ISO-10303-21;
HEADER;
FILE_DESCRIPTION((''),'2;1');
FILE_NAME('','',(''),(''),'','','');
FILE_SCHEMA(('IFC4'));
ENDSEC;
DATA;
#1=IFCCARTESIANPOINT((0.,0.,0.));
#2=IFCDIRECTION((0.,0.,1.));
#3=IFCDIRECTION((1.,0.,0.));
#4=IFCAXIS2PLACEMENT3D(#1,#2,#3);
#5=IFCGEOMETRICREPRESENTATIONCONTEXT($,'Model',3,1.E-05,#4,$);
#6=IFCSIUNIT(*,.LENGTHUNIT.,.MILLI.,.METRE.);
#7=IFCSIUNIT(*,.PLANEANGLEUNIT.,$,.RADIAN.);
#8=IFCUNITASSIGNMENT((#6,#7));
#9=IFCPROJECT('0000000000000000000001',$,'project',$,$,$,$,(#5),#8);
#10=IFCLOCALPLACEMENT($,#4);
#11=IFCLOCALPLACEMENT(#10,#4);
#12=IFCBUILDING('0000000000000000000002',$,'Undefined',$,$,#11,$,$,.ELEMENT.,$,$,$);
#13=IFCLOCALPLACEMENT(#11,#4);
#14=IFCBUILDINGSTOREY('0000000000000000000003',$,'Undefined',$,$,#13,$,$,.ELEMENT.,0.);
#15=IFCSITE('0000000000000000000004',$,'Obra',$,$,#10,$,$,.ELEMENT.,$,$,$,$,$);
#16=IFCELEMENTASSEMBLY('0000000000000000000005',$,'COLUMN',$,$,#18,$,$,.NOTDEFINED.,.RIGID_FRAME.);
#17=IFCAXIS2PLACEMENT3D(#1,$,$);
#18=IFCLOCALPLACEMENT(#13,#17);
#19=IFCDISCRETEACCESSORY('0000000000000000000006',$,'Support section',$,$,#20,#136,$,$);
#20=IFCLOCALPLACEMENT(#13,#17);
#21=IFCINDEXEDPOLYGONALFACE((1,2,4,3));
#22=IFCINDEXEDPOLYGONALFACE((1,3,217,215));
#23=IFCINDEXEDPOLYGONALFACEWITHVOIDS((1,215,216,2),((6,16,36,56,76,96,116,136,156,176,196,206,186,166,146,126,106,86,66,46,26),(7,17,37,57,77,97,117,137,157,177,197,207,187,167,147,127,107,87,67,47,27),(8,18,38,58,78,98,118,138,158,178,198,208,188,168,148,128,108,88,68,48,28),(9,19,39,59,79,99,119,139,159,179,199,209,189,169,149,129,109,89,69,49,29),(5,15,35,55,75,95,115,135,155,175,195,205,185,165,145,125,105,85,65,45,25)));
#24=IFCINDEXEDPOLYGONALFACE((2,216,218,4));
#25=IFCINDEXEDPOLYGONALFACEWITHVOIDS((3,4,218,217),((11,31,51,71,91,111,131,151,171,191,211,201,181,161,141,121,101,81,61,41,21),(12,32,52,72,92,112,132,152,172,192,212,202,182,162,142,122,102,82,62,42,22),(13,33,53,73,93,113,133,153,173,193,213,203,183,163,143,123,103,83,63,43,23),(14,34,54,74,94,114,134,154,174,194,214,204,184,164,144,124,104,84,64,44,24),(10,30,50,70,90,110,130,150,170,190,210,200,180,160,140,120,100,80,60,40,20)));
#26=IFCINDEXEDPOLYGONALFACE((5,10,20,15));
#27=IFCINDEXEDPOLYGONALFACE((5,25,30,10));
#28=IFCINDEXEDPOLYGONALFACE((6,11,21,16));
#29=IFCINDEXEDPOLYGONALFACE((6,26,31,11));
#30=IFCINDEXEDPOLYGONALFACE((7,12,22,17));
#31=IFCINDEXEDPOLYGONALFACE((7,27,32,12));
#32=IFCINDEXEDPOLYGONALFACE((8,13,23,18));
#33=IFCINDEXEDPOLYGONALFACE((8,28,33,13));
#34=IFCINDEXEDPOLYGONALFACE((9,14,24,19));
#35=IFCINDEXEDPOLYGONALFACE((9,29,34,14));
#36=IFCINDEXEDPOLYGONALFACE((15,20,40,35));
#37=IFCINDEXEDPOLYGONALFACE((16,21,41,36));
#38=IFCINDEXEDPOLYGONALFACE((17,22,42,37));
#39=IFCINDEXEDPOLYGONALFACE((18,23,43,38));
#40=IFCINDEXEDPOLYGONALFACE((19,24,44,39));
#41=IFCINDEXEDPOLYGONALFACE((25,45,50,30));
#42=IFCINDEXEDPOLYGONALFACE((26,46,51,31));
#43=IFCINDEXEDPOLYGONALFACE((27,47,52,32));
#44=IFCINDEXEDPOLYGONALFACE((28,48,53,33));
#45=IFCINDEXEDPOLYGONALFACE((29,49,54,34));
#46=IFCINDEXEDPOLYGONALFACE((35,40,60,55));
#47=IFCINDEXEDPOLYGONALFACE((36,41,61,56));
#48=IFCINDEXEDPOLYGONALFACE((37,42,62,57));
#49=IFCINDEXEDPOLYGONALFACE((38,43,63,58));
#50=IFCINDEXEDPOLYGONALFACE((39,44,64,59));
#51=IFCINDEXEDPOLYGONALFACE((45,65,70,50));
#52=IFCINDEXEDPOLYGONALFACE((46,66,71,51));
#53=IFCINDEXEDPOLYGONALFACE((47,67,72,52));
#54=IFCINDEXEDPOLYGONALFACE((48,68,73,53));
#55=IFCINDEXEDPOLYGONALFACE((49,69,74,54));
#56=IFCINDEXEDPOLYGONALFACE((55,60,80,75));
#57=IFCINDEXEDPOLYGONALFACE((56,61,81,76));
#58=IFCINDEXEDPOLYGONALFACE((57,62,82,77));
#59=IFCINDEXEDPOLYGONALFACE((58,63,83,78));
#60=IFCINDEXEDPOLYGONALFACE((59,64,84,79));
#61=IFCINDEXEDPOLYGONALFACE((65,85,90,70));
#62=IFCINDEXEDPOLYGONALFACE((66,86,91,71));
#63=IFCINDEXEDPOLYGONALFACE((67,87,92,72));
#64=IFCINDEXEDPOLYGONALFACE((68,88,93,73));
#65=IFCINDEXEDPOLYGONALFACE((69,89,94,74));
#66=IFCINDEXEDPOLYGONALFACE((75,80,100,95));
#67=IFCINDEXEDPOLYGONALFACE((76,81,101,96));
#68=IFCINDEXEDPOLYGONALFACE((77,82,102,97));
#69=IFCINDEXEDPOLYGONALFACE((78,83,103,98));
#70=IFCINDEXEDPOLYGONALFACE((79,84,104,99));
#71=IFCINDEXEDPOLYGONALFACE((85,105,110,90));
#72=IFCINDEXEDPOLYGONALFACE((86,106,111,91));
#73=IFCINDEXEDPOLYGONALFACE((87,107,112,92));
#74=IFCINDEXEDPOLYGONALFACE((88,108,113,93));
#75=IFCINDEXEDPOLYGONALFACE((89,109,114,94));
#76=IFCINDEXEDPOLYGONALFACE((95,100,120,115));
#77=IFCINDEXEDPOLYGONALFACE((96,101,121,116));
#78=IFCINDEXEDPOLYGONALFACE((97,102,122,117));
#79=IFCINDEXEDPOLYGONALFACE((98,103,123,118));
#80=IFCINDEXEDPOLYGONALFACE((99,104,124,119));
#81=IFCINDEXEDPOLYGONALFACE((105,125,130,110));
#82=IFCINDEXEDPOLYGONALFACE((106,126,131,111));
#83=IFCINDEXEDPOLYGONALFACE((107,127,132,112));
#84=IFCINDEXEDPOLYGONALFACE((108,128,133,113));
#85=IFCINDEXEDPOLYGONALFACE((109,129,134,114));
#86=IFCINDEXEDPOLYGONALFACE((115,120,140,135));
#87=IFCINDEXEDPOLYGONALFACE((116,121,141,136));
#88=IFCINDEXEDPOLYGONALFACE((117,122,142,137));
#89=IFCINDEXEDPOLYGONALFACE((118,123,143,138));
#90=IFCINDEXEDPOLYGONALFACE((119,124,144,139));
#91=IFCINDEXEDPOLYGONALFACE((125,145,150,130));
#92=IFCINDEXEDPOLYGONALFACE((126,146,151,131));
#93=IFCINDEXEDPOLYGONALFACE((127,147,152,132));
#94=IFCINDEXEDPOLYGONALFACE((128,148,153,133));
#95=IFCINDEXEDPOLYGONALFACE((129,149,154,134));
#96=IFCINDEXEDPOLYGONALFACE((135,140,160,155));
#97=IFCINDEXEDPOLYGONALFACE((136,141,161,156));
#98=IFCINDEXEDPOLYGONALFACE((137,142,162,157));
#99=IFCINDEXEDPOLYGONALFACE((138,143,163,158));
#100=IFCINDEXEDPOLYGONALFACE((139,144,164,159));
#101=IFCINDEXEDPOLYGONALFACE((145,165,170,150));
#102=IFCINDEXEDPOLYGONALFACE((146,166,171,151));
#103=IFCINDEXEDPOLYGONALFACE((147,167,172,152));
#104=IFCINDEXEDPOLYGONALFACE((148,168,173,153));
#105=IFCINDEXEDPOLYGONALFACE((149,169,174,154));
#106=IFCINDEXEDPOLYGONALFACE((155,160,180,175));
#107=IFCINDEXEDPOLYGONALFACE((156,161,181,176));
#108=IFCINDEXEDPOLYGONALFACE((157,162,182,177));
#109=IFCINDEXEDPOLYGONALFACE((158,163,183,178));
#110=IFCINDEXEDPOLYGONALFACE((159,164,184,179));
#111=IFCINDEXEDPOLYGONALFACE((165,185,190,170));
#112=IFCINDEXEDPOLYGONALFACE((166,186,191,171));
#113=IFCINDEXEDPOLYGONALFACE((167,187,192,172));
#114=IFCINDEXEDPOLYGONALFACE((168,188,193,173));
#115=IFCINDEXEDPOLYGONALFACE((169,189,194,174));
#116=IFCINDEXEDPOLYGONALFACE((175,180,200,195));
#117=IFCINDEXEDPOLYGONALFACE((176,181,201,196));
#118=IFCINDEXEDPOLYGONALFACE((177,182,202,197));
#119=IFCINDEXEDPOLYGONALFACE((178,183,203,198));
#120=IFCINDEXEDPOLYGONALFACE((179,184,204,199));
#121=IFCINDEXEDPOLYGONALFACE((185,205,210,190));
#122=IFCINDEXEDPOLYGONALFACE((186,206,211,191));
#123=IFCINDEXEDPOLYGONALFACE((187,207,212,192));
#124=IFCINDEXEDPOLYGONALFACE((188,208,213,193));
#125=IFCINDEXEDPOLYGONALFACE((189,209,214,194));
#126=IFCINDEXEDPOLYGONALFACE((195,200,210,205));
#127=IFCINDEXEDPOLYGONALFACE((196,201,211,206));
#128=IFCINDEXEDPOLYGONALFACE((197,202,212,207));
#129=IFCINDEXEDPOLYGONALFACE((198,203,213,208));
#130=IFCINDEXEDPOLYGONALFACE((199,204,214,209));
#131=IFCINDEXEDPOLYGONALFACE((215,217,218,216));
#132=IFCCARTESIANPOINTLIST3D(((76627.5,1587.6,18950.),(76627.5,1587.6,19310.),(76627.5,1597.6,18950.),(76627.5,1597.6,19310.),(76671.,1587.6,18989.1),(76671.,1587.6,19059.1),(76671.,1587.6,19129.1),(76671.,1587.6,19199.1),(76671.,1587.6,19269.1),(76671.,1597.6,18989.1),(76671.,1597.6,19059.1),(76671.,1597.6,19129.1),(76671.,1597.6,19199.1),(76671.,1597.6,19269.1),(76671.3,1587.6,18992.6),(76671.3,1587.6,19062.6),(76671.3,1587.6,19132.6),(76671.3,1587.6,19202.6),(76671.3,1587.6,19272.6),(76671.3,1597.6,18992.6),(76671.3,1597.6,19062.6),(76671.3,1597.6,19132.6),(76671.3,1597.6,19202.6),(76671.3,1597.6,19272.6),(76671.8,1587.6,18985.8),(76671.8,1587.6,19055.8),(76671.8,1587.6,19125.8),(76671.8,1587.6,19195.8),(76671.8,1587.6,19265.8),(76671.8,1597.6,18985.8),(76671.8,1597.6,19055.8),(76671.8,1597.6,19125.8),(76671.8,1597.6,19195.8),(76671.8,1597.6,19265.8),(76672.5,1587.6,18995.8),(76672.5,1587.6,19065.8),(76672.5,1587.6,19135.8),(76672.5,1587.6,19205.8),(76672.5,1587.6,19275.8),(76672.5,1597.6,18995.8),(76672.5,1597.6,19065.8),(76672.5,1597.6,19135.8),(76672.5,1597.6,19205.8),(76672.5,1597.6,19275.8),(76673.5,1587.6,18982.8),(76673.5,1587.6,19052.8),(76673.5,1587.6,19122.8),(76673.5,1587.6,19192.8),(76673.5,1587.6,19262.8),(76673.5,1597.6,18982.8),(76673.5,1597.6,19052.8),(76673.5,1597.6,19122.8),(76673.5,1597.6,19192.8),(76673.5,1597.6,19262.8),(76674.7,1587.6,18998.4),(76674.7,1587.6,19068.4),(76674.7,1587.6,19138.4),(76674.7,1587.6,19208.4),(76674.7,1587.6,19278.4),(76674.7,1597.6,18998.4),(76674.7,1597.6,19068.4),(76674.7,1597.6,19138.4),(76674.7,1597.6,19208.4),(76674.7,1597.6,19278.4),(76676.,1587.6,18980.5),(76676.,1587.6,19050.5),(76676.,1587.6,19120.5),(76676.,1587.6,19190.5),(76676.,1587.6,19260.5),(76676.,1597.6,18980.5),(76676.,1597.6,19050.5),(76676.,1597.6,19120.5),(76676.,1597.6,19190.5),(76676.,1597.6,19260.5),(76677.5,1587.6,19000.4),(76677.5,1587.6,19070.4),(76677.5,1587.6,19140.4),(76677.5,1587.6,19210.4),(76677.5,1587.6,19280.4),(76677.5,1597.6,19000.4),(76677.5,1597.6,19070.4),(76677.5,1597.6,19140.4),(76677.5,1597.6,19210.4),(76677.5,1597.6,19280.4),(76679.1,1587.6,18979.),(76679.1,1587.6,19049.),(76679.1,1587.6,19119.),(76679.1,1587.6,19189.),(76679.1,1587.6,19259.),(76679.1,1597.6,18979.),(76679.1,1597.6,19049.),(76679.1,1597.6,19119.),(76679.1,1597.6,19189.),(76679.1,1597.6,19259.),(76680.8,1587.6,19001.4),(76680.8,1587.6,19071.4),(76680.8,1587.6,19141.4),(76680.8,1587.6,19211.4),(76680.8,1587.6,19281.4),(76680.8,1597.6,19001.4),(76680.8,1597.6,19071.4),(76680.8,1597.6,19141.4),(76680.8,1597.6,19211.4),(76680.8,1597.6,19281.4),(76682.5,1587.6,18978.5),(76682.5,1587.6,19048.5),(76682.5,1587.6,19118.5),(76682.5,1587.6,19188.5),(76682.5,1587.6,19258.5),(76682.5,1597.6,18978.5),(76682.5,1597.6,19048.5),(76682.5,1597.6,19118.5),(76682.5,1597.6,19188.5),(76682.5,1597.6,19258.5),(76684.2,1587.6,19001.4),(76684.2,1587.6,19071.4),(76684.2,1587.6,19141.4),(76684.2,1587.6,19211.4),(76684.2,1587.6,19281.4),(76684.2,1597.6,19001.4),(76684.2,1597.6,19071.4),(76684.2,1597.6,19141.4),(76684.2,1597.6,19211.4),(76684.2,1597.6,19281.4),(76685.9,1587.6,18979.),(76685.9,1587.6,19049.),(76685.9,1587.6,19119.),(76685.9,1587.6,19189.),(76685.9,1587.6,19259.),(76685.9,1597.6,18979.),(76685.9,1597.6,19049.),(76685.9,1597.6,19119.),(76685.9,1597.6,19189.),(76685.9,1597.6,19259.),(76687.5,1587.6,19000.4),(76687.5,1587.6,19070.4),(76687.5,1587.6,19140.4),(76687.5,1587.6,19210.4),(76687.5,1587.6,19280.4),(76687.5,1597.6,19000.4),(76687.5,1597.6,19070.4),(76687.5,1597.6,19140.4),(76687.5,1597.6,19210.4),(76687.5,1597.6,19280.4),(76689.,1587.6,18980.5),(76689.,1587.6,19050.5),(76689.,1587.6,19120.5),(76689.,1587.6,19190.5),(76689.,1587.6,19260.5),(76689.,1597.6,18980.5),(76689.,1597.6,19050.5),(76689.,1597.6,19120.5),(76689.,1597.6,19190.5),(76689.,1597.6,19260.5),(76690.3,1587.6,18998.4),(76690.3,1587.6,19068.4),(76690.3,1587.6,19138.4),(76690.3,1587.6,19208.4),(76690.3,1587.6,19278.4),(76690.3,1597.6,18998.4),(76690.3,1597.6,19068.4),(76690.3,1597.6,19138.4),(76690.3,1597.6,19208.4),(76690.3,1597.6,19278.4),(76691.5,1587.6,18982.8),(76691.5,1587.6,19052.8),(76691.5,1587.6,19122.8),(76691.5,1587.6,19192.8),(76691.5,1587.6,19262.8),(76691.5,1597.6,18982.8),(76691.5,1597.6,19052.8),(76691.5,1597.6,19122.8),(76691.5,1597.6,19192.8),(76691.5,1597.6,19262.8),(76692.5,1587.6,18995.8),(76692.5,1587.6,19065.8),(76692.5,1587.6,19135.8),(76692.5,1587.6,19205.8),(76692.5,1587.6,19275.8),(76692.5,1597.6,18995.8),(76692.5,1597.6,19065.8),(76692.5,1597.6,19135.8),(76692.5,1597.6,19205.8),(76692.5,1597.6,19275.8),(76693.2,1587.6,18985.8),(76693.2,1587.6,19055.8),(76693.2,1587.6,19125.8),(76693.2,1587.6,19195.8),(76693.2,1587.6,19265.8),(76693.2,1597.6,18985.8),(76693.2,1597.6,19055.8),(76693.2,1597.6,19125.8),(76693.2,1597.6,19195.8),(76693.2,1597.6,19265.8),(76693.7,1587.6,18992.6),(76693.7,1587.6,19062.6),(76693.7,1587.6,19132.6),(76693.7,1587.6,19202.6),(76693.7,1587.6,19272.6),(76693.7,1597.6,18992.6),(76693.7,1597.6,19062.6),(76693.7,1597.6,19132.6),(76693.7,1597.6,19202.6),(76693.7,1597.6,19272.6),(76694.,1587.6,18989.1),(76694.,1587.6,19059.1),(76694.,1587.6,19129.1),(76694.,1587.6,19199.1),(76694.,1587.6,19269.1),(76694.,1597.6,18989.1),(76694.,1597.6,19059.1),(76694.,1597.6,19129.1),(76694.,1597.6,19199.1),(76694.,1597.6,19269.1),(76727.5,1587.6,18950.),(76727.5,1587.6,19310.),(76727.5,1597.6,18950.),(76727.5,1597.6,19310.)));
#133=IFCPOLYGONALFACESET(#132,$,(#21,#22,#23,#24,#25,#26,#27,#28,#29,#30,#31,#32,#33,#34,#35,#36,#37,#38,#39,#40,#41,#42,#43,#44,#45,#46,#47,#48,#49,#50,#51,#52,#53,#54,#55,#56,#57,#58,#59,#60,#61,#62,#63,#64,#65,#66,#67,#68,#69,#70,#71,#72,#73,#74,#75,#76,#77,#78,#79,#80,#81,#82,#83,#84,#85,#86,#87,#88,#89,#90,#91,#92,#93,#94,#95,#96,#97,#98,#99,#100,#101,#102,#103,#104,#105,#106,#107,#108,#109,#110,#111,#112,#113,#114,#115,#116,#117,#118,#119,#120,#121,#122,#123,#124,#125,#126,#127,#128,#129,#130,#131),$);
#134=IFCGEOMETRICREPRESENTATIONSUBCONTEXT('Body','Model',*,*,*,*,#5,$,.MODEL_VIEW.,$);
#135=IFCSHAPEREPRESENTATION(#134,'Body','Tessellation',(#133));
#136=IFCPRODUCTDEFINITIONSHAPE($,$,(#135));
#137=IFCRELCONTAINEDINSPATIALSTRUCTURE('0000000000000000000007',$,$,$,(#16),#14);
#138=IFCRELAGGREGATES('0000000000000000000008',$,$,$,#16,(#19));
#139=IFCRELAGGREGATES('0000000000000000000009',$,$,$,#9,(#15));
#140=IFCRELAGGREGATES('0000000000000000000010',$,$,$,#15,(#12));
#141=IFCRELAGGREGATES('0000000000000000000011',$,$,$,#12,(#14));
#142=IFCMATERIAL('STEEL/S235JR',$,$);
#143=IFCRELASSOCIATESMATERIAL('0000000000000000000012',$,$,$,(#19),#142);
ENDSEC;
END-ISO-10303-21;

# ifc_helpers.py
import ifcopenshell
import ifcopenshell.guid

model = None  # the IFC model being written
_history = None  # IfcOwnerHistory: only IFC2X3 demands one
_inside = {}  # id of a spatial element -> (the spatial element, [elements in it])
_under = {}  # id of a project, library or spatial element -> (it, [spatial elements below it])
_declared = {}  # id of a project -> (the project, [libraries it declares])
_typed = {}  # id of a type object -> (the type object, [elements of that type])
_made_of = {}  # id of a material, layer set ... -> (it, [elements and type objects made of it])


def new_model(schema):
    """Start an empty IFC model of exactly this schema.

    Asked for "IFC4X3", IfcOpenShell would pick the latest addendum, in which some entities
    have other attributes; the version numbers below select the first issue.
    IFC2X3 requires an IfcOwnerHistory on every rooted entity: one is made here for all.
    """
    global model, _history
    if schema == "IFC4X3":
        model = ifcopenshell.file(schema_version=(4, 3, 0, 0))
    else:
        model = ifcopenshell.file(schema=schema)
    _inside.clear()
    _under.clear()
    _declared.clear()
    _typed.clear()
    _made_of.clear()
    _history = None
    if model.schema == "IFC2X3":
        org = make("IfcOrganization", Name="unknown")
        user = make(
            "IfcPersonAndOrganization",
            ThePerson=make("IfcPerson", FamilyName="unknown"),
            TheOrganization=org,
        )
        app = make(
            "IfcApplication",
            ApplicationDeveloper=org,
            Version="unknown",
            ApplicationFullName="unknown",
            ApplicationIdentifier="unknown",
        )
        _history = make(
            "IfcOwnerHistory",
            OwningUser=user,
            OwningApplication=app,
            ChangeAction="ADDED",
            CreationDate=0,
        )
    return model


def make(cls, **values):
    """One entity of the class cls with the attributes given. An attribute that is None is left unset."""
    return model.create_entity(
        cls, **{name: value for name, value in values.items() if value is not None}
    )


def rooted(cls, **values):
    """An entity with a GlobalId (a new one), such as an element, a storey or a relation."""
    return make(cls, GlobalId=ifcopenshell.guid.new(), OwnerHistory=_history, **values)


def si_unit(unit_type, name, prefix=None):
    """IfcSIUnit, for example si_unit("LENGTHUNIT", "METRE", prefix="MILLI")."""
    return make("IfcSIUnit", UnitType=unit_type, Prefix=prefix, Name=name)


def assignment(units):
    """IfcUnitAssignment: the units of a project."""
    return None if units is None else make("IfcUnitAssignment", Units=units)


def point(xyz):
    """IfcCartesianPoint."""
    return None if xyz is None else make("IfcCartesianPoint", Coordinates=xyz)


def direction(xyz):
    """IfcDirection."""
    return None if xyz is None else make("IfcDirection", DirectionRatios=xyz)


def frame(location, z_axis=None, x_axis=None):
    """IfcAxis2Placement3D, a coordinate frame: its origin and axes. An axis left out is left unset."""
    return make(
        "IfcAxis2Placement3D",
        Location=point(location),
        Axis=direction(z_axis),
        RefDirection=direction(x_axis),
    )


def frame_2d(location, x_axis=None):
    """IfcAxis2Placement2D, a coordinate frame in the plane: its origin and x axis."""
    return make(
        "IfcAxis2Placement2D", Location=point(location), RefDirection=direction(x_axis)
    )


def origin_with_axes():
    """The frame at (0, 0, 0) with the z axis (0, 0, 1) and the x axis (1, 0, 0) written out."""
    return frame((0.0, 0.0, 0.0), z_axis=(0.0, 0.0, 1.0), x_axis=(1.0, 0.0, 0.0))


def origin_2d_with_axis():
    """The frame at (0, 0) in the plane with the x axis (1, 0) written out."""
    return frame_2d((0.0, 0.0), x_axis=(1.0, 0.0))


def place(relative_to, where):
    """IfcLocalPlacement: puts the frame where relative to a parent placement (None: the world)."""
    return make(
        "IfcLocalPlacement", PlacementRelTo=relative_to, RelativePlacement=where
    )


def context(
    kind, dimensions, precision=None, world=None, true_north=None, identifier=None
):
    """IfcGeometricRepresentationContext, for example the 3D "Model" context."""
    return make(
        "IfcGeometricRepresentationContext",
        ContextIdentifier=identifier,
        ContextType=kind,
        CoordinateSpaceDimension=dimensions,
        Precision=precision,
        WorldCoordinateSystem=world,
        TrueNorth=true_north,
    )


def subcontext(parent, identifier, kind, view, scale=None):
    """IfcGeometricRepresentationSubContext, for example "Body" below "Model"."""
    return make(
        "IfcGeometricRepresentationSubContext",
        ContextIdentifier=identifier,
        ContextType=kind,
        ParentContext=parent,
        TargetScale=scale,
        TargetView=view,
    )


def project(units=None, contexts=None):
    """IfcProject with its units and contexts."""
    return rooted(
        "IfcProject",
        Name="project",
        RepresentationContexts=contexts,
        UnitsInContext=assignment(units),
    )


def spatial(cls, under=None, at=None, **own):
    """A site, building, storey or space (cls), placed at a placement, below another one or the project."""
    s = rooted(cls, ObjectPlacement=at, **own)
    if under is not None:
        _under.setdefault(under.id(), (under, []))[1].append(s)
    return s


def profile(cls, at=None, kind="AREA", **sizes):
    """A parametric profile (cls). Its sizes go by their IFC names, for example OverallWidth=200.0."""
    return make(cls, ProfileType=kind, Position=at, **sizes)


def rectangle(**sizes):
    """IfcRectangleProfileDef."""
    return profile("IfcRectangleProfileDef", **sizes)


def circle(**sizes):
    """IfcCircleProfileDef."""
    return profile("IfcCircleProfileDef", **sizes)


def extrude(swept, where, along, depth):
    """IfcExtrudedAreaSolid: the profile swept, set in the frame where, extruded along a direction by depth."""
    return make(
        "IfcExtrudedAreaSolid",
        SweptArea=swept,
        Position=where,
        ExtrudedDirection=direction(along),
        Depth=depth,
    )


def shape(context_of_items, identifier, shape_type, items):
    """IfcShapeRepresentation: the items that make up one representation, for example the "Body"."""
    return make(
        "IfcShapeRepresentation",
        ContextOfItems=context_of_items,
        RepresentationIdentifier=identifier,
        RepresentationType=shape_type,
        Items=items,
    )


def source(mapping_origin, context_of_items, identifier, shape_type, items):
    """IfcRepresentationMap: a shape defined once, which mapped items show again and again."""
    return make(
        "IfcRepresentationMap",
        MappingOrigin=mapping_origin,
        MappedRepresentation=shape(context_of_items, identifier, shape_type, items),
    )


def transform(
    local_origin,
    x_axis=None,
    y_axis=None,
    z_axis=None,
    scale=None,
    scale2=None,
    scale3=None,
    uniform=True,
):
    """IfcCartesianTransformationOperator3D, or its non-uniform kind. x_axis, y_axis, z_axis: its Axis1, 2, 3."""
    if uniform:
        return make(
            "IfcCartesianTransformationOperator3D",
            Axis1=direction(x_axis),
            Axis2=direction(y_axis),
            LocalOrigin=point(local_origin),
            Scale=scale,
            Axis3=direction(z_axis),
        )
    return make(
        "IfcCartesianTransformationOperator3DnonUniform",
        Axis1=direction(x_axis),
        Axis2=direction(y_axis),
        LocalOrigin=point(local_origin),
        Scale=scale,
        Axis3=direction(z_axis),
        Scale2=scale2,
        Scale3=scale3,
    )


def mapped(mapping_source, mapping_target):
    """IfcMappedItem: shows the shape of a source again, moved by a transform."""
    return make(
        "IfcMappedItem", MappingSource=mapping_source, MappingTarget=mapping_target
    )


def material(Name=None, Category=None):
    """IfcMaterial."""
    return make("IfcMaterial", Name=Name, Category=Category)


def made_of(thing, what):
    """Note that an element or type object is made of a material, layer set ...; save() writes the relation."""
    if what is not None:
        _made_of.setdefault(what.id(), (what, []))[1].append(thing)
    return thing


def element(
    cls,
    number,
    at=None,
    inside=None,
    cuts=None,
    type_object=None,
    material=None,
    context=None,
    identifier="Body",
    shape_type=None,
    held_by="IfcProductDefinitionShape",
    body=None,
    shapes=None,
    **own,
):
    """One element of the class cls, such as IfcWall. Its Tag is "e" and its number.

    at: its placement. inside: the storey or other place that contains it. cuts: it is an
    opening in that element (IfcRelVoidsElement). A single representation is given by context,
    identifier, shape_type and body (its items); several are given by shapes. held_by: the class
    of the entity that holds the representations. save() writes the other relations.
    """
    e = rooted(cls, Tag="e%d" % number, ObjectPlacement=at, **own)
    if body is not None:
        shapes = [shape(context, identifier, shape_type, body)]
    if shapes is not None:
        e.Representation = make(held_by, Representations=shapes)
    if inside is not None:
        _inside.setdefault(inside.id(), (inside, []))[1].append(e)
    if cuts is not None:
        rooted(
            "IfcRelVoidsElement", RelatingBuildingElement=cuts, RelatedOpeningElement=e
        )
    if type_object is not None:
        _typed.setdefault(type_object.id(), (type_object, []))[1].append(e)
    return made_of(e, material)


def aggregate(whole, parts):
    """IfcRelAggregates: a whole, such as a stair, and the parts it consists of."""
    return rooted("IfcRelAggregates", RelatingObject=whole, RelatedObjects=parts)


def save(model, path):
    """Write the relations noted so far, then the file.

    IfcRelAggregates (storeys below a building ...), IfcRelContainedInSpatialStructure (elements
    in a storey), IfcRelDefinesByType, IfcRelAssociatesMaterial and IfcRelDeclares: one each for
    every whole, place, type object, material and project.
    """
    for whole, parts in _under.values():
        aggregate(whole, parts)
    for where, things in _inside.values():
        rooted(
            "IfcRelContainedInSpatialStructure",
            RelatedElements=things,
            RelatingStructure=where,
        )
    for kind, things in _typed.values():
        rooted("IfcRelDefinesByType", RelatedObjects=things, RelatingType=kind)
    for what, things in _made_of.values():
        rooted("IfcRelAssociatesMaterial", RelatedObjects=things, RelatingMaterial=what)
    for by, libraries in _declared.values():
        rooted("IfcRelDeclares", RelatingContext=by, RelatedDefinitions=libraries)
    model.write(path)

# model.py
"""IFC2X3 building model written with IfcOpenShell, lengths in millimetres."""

from ifc_helpers import new_model, si_unit, frame, origin_with_axes, origin_2d_with_axis, place, context, subcontext, project, spatial, rectangle, circle, extrude, source, transform, mapped, material, element, aggregate, save


model = new_model("IFC2X3")

# Units and contexts
model_context = context("Model", 3, precision=1e-05, world=origin_with_axes())
body_context = subcontext(model_context, "Body", "Model", "MODEL_VIEW")
ifc_project = project(units=[si_unit("LENGTHUNIT", "METRE", prefix="MILLI"), si_unit("PLANEANGLEUNIT", "RADIAN")], contexts=[model_context])

# Site, building, storey
site_placement = place(None, origin_with_axes())
site = spatial("IfcSite", under=ifc_project, at=site_placement, Name="Obra", CompositionType="ELEMENT")
building_placement = place(site_placement, origin_with_axes())
building = spatial("IfcBuilding", under=site, at=building_placement, Name="Undefined", CompositionType="ELEMENT")
storey_placement = place(building_placement, origin_with_axes())
storey = spatial("IfcBuildingStorey", under=building, at=storey_placement, Name="Undefined", CompositionType="ELEMENT", Elevation=0.0)

# Shared definitions
ifc_material_1 = material(Name="STEEL/S235JR")

# Element assembly, discrete accessory, opening
assembly_1_placement = place(storey_placement, origin_with_axes())
assembly_1 = element("IfcElementAssembly", 1, at=assembly_1_placement, inside=storey, Name="COLUMN", AssemblyPlace="NOTDEFINED", PredefinedType="RIGID_FRAME")
discrete_accessory_1_placement = place(assembly_1_placement, frame((76677.5, 1592.6, 18950.0), z_axis=(0.0, 0.0, 1.0), x_axis=(-1.0, 0.0, 0.0)))
discrete_accessory_1 = element("IfcDiscreteAccessory", 2, at=discrete_accessory_1_placement, material=ifc_material_1, Name="Support section", context=body_context, shape_type="SweptSolid", body=[
    extrude(rectangle(XDim=10.0, YDim=100.0, at=origin_2d_with_axis()), frame((0.0, 0.0, 360.0), z_axis=(0.0, 0.0, -1.0), x_axis=(0.0, 1.0, 0.0)), (0.0, 0.0, 1.0), 360.0),
])
shared_shape_1 = source(origin_with_axes(), body_context, "Body", "SweptSolid", [
    extrude(circle(Radius=11.5, at=origin_2d_with_axis()), frame((0.0, -15.8, 0.0), z_axis=(0.0, 1.0, 0.0), x_axis=(1.0, 0.0, 0.0)), (0.0, 0.0, 1.0), 10.2),
])
opening_1_placement = place(assembly_1_placement, frame((76637.5, 1603.4, 19350.0), z_axis=(1.0, 0.0, 0.0), x_axis=(0.0, 0.0, -1.0)))
element("IfcOpeningElement", 3, at=opening_1_placement, cuts=discrete_accessory_1, ObjectType="Opening", context=body_context, shape_type="MappedRepresentation", body=[
    mapped(shared_shape_1, transform((80.0, 0.0, 45.0))),
    mapped(shared_shape_1, transform((150.0, 0.0, 45.0))),
    mapped(shared_shape_1, transform((220.0, 0.0, 45.0))),
    mapped(shared_shape_1, transform((290.0, 0.0, 45.0))),
    mapped(shared_shape_1, transform((360.0, 0.0, 45.0))),
])
aggregate(assembly_1, [discrete_accessory_1])

save(model, "model.ifc")
